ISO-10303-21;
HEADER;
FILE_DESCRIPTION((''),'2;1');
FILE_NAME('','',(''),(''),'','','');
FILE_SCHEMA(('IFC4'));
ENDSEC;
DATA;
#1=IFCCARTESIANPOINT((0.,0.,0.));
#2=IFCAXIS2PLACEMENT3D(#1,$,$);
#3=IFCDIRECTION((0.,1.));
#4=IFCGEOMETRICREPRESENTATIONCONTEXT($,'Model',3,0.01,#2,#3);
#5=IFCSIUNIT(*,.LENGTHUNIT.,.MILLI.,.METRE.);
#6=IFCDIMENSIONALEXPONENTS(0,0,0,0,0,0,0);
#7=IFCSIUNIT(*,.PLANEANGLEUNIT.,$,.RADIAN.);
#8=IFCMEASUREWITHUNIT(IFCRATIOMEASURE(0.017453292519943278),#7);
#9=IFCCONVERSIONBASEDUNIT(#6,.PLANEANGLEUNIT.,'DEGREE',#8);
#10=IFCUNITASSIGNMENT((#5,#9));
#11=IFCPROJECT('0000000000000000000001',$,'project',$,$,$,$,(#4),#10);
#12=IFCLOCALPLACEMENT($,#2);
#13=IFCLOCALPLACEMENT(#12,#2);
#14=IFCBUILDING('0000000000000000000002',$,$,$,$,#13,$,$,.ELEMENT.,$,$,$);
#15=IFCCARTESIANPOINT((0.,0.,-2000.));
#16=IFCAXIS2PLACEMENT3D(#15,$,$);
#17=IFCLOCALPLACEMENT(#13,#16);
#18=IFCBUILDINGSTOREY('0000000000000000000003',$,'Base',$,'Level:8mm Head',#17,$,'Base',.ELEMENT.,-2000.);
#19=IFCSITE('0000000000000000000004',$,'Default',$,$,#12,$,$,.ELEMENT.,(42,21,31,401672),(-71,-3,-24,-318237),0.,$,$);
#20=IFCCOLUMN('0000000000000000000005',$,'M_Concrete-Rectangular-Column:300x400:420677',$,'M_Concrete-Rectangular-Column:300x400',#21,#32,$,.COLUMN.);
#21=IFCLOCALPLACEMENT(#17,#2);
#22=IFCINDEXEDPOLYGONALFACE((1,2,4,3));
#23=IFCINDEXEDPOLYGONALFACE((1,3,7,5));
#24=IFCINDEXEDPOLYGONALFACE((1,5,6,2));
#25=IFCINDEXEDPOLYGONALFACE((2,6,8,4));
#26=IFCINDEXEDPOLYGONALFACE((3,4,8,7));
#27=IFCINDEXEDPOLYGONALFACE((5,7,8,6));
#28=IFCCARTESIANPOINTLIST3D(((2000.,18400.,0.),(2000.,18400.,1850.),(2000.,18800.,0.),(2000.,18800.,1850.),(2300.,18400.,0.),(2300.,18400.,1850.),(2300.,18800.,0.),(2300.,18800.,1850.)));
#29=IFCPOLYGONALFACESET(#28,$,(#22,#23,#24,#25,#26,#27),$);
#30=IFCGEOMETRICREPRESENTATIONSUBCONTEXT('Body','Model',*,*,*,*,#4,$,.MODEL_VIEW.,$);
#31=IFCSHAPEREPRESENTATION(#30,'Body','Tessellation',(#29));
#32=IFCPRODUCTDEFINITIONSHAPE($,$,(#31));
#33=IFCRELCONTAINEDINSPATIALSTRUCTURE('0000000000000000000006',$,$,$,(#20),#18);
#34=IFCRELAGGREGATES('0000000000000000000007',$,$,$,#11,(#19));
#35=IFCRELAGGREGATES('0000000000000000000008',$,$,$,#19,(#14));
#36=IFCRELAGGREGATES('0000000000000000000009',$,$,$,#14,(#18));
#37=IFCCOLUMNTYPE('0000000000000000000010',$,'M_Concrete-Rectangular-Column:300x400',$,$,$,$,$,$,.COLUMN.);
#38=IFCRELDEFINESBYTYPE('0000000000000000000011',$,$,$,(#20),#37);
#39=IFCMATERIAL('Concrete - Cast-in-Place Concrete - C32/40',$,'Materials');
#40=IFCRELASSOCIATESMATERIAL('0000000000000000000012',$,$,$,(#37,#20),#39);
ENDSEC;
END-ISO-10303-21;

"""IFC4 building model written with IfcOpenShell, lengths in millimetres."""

from ifc_helpers import new_model, entity, si_unit, converted_unit, direction, frame, origin, place, context, subcontext, project, spatial, indexed_curve, outline, extrude, source, transform, mapped, material, type_object, type_shapes, element, save


model = new_model("IFC4")

# Units and contexts
model_context = context("Model", 3, precision=0.01, world=origin(), true_north=direction((0.0, 1.0)))
body_context = subcontext(model_context, "Body", "Model", "MODEL_VIEW")
ifc_project = project(units=[si_unit("LENGTHUNIT", "METRE", prefix="MILLI"), converted_unit("PLANEANGLEUNIT", "DEGREE", entity("IfcRatioMeasure", 0.017453292519943278), si_unit("PLANEANGLEUNIT", "RADIAN"), dimensions=[0, 0, 0, 0, 0, 0, 0])], contexts=[model_context])

# Site, building, storey
site_placement = place(None, origin())
site = spatial("IfcSite", under=ifc_project, at=site_placement, Name="Default", CompositionType="ELEMENT", RefLatitude=(42, 21, 31, 401672), RefLongitude=(-71, -3, -24, -318237), RefElevation=0.0)
building_placement = place(site_placement, origin())
building = spatial("IfcBuilding", under=site, at=building_placement, CompositionType="ELEMENT")
storey_placement = place(building_placement, frame((0.0, 0.0, -2000.0)))
storey = spatial("IfcBuildingStorey", under=building, at=storey_placement, Name="Base", ObjectType="Level:8mm Head", LongName="Base", CompositionType="ELEMENT", Elevation=-2000.0)

# Column
ifc_material = material(Name="Concrete - Cast-in-Place Concrete - C32/40", Category="Materials")
column_type_1 = type_object("IfcColumnType", Name="M_Concrete-Rectangular-Column:300x400", PredefinedType="COLUMN", material=ifc_material)
shared_shape_1 = source(origin(), body_context, "Body", "SweptSolid", [
    extrude(outline(indexed_curve([(-200.0, -150.0), (200.0, -150.0), (200.0, 150.0), (-200.0, 150.0), (-200.0, -150.0)], self_intersect=False)), frame((2150.0, 18600.0, -2000.0), z_axis=(0.0, 0.0, 1.0), x_axis=(0.0, -1.0, 0.0)), (0.0, 0.0, 1.0), 1850.0),
])
type_shapes(column_type_1, [shared_shape_1])
column_1_placement = place(storey_placement, frame((0.0, 0.0, 2000.0)))
element("IfcColumn", 1, at=column_1_placement, inside=storey, type_object=column_type_1, material=ifc_material, Name="M_Concrete-Rectangular-Column:300x400:420677", ObjectType="M_Concrete-Rectangular-Column:300x400", PredefinedType="COLUMN", context=body_context, shape_type="MappedRepresentation", body=[
    mapped(shared_shape_1, transform((0.0, 0.0, 0.0), scale=1.0)),
])

save(model, "model.ifc")
